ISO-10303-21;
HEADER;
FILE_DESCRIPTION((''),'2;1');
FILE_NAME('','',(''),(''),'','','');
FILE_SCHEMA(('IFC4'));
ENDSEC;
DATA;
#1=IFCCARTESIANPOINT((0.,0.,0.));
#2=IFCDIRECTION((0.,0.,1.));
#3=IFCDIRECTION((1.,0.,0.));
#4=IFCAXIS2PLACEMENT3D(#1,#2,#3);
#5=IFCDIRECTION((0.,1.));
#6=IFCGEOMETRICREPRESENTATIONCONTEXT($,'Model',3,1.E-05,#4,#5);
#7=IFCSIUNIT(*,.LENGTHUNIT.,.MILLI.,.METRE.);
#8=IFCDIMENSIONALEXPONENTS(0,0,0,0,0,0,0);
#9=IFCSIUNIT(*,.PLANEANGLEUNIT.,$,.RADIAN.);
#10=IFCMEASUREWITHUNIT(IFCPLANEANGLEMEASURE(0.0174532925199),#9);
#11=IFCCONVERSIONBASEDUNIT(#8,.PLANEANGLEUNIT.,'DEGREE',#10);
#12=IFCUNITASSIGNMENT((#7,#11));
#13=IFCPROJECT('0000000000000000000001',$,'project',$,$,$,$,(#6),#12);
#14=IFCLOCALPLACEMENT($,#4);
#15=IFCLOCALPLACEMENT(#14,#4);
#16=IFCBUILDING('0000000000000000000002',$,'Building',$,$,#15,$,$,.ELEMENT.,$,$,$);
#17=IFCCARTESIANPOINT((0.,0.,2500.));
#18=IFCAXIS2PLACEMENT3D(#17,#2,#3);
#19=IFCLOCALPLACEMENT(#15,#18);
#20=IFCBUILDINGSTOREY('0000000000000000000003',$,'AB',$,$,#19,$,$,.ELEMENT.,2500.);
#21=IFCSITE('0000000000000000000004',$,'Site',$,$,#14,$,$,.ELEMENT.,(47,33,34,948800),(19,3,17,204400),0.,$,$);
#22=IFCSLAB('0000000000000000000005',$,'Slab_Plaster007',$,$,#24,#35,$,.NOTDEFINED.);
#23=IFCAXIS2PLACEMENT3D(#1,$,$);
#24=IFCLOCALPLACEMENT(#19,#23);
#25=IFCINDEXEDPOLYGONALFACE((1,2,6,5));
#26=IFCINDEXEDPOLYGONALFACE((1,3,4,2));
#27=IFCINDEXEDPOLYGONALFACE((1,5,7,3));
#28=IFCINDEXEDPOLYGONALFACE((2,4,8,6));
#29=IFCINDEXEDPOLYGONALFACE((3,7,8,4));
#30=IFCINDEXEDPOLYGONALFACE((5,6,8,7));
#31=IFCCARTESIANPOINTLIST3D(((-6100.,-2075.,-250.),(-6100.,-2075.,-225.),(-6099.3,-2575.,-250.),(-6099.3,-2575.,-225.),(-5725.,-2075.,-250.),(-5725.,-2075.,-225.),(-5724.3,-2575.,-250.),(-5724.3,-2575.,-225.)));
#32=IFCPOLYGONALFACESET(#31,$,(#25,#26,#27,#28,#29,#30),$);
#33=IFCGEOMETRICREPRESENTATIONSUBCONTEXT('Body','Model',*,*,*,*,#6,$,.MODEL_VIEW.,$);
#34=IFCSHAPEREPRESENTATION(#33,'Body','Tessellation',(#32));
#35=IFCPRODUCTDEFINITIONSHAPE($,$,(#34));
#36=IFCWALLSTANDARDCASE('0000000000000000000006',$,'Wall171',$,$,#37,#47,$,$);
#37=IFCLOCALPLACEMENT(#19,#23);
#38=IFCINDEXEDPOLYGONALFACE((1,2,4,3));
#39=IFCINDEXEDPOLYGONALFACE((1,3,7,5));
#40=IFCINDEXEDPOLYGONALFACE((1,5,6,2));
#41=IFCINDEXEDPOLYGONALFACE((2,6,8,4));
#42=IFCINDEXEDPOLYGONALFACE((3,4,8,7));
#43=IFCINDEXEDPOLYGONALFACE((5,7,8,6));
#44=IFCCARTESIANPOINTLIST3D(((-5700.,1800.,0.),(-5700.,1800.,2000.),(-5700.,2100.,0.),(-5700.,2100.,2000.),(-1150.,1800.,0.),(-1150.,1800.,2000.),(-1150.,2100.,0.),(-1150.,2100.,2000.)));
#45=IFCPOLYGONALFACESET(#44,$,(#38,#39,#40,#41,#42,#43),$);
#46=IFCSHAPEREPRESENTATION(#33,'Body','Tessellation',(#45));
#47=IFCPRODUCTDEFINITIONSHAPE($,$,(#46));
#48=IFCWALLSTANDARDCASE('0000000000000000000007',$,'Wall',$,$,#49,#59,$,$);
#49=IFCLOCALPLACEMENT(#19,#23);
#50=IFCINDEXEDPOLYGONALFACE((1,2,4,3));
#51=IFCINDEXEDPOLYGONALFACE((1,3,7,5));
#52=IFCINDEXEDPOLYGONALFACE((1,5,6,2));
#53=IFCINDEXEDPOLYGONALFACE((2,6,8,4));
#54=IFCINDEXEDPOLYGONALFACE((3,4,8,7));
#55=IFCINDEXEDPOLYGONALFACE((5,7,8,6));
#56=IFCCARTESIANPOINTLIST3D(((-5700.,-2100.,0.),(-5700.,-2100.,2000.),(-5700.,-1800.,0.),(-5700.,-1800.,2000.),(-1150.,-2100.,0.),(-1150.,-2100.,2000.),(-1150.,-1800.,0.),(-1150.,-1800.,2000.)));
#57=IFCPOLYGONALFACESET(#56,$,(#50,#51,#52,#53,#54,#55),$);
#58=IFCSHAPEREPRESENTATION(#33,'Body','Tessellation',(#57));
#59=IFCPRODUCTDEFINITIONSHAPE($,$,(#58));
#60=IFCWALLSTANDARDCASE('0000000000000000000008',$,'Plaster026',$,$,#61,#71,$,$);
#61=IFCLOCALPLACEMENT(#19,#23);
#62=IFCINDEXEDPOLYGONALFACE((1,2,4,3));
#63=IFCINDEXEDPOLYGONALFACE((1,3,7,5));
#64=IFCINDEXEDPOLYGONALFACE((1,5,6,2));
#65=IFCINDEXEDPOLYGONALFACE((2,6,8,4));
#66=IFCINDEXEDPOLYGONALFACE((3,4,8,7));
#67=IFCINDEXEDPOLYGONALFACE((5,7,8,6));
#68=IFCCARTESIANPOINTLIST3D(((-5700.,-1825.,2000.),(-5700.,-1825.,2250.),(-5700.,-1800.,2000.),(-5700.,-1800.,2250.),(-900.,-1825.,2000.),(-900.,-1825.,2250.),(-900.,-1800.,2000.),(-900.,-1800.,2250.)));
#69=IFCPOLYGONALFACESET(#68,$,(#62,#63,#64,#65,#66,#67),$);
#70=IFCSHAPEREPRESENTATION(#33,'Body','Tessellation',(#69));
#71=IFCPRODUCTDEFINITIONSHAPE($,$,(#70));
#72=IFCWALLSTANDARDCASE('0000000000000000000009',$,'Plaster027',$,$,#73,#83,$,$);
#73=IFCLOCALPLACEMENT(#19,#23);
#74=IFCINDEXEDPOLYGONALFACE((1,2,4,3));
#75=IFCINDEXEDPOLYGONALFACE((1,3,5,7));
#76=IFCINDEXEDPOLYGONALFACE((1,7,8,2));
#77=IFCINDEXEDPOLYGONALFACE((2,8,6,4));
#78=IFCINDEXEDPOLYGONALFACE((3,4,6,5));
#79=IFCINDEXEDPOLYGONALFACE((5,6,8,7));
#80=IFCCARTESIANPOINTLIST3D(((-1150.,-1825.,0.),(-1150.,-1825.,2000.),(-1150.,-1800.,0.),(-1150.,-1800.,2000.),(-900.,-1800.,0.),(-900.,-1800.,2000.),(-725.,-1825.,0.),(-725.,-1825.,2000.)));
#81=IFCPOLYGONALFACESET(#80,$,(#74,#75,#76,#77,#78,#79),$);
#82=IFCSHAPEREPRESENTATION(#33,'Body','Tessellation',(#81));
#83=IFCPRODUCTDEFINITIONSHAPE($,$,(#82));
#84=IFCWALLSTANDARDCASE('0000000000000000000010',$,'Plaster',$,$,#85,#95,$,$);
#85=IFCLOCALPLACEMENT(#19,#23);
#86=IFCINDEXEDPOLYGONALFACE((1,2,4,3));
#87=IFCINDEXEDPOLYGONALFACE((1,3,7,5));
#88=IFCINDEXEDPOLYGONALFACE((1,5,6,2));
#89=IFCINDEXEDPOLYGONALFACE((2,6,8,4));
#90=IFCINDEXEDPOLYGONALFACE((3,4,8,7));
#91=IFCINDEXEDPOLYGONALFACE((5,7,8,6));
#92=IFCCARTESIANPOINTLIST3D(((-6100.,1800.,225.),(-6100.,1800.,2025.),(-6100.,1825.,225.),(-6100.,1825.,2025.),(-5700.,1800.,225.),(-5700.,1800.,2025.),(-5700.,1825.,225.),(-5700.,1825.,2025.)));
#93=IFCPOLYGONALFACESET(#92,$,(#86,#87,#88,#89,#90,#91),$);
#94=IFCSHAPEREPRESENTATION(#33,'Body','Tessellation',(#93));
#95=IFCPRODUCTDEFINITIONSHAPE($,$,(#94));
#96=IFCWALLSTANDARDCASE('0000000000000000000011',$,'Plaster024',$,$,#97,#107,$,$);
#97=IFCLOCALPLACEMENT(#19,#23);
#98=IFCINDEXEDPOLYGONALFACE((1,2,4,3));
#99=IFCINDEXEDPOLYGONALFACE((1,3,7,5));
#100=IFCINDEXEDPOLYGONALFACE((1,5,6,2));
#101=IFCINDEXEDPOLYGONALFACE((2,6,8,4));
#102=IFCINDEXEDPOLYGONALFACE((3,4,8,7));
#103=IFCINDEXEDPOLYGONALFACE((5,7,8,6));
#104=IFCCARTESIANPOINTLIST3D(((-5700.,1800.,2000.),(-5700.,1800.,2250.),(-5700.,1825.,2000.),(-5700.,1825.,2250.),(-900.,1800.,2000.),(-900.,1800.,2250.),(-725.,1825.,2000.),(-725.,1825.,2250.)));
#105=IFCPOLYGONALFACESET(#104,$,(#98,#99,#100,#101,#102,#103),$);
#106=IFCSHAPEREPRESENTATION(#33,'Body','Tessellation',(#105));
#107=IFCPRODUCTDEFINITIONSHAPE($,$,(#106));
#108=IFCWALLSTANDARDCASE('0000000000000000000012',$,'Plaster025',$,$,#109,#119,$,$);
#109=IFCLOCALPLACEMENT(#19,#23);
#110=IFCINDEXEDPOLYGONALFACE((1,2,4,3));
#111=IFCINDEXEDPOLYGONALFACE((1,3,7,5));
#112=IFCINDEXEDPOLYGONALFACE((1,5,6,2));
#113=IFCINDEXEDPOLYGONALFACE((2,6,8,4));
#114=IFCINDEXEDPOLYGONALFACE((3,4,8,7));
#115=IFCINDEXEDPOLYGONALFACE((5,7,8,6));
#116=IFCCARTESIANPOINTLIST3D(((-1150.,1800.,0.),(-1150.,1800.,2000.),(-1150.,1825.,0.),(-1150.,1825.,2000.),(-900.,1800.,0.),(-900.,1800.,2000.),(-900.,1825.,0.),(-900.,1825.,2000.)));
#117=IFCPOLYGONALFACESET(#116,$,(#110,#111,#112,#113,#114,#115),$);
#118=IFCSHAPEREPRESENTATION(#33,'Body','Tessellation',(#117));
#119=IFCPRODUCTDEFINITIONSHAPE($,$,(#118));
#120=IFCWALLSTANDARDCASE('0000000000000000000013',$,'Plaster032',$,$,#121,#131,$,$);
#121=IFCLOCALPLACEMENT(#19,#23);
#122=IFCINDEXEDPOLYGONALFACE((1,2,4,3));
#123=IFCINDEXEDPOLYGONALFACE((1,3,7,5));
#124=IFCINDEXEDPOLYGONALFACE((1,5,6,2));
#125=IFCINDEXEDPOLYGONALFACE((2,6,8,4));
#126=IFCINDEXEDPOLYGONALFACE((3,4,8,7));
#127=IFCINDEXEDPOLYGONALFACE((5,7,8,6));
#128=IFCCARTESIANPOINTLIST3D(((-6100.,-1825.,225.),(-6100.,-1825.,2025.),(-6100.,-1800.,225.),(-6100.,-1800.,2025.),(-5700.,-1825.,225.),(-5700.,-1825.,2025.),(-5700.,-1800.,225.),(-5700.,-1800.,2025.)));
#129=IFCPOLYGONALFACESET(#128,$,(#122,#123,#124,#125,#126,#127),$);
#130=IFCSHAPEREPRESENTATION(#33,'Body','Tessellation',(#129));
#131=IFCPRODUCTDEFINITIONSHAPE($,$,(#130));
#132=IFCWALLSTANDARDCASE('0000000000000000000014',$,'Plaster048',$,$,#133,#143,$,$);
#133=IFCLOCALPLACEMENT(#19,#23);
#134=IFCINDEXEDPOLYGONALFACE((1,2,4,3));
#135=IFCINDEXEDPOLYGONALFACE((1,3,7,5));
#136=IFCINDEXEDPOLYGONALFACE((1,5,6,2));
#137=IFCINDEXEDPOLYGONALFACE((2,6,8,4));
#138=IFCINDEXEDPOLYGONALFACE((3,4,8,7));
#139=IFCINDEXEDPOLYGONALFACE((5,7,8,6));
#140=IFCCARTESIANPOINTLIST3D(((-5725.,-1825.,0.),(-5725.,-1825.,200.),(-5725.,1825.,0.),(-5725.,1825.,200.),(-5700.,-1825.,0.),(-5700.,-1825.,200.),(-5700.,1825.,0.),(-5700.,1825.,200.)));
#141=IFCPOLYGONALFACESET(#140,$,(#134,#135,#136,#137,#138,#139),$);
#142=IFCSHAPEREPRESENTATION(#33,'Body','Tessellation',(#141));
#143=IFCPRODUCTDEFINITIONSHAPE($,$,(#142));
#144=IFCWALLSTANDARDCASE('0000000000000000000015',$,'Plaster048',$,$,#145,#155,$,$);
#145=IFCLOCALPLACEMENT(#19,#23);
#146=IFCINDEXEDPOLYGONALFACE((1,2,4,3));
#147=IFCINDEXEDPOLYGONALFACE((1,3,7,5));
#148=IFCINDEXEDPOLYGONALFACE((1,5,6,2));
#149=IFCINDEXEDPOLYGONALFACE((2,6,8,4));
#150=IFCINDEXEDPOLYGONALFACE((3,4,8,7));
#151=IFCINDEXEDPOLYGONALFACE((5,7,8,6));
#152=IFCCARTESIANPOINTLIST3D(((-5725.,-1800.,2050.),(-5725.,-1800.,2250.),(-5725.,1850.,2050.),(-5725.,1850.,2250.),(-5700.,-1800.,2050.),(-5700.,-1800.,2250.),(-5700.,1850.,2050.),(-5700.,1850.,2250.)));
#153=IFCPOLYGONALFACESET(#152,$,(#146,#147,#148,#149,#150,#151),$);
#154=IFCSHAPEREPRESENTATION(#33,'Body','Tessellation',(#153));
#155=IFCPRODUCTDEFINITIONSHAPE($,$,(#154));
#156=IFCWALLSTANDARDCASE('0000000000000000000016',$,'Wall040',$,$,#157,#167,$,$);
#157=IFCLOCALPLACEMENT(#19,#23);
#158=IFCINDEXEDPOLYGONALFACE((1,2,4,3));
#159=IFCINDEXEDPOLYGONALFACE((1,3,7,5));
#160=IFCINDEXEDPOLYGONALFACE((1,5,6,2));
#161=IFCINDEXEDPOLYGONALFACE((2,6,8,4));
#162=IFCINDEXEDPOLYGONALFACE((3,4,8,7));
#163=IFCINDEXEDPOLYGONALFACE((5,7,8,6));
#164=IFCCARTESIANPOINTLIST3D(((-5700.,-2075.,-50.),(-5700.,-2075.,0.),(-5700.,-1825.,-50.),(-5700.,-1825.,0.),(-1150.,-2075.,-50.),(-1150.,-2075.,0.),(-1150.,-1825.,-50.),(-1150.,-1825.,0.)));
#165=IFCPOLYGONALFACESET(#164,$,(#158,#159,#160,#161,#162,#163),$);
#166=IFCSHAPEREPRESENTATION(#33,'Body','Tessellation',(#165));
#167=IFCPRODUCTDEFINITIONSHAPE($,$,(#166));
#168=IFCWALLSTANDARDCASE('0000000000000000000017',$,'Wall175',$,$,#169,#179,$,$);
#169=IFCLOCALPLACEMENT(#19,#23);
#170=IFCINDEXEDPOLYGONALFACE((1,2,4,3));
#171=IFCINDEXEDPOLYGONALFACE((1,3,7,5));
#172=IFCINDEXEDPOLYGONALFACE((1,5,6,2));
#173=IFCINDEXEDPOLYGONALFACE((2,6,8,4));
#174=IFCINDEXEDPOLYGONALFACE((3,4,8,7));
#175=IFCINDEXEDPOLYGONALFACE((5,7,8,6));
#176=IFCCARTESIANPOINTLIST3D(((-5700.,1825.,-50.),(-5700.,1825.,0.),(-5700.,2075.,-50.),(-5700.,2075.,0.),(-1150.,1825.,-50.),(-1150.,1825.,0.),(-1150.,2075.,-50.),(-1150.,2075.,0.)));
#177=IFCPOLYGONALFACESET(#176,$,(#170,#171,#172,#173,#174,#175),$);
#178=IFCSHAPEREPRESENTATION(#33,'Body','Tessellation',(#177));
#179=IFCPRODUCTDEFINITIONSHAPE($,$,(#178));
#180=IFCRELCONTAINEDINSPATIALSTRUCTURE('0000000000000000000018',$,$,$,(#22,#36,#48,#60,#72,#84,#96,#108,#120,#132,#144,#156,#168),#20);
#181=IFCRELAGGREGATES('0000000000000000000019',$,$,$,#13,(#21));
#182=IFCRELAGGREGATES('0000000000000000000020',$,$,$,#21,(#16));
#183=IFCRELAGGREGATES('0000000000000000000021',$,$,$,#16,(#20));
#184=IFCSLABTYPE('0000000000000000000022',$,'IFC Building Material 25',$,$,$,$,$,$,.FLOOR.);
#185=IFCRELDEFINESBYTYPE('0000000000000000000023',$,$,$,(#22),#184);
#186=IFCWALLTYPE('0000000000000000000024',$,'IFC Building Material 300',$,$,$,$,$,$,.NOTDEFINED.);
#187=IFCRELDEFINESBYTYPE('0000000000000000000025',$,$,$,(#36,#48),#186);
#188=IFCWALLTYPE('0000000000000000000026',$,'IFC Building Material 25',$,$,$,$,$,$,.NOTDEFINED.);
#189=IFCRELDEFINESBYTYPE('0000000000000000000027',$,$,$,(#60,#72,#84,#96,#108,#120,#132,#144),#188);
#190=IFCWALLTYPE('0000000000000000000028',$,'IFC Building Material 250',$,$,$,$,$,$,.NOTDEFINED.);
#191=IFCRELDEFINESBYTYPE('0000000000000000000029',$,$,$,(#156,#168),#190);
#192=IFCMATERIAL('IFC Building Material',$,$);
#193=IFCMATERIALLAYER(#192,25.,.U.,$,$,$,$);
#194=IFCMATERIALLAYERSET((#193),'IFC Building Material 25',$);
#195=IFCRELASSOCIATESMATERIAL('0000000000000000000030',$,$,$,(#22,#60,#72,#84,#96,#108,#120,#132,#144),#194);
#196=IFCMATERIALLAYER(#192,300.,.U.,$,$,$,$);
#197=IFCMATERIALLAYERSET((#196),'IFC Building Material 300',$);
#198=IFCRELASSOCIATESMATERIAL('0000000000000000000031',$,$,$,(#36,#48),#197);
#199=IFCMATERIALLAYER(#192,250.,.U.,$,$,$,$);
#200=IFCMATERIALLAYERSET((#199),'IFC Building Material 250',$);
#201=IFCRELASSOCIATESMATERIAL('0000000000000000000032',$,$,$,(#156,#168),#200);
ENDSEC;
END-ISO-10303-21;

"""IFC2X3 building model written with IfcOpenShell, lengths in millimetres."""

from ifc_helpers import new_model, entity, si_unit, converted_unit, direction, frame, origin_with_axes, place, context, subcontext, project, spatial, polyline, outline, extrude, material, layer, layer_set, layer_usage, type_object, element, save


model = new_model("IFC2X3")

# Units and contexts
model_context = context("Model", 3, precision=1e-05, world=origin_with_axes(), true_north=direction((0.0, 1.0)))
body_context = subcontext(model_context, "Body", "Model", "MODEL_VIEW")
ifc_project = project(units=[si_unit("LENGTHUNIT", "METRE", prefix="MILLI"), converted_unit("PLANEANGLEUNIT", "DEGREE", entity("IfcPlaneAngleMeasure", 0.0174532925199), si_unit("PLANEANGLEUNIT", "RADIAN"), dimensions=[0, 0, 0, 0, 0, 0, 0])], contexts=[model_context])

# Site, building, storey
site_placement = place(None, origin_with_axes())
site = spatial("IfcSite", under=ifc_project, at=site_placement, Name="Site", CompositionType="ELEMENT", RefLatitude=(47, 33, 34, 948800), RefLongitude=(19, 3, 17, 204400), RefElevation=0.0)
building_placement = place(site_placement, origin_with_axes())
building = spatial("IfcBuilding", under=site, at=building_placement, Name="Building", CompositionType="ELEMENT")
storey_placement = place(building_placement, frame((0.0, 0.0, 2500.0), z_axis=(0.0, 0.0, 1.0), x_axis=(1.0, 0.0, 0.0)))
storey = spatial("IfcBuildingStorey", under=building, at=storey_placement, Name="AB", CompositionType="ELEMENT", Elevation=2500.0)

# Shared definitions
ifc_material = material(Name="IFC Building Material")

# Slab
ifc_layer_1 = layer(ifc_material, 250.0, ventilated="UNKNOWN")
ifc_layer_set_1 = layer_set([ifc_layer_1], Name="IFC Building Material 250")
ifc_layer_2 = layer(ifc_material, 25.0, ventilated="UNKNOWN")
ifc_layer_set_2 = layer_set([ifc_layer_2], Name="IFC Building Material 25")
slab_type_1 = type_object("IfcSlabType", Name="IFC Building Material 25", PredefinedType="FLOOR")
ifc_layer_usage_1 = layer_usage(ifc_layer_set_2, "AXIS3", "NEGATIVE", 25.0)
slab_1_placement = place(storey_placement, frame((-5725.0, -2075.0, -225.0), z_axis=(0.0, 0.0, 1.0), x_axis=(1.0, 0.0, 0.0)))
element("IfcSlab", 1, at=slab_1_placement, inside=storey, type_object=slab_type_1, material=ifc_layer_usage_1, Name="Slab_Plaster007", PredefinedType="NOTDEFINED", context=body_context, shape_type="SweptSolid", body=[
    extrude(outline(polyline([(0.0, 0.0), (-375.0, 0.0), (-374.3, -500.0), (0.7, -500.0), (0.0, 0.0)])), frame((0.0, 0.0, -25.0), z_axis=(0.0, 0.0, 1.0), x_axis=(1.0, 0.0, 0.0)), (0.0, 0.0, 1.0), 25.0),
])

# Walls
ifc_layer_3 = layer(ifc_material, 300.0, ventilated="UNKNOWN")
ifc_layer_set_3 = layer_set([ifc_layer_3], Name="IFC Building Material 300")
ifc_layer_usage_2 = layer_usage(ifc_layer_set_3, "AXIS2", "NEGATIVE", 0.0)
wall_type_1 = type_object("IfcWallType", Name="IFC Building Material 300", PredefinedType="NOTDEFINED")
wall_1_placement = place(storey_placement, frame((-1150.0, 1800.0, 0.0), z_axis=(0.0, 0.0, 1.0), x_axis=(-1.0, 0.0, 0.0)))
element("IfcWallStandardCase", 2, at=wall_1_placement, inside=storey, type_object=wall_type_1, material=ifc_layer_usage_2, Name="Wall171", context=body_context, shape_type="SweptSolid", body=[
    extrude(outline(polyline([(0.0, -300.0), (4550.0, -300.0), (4550.0, 0.0), (0.0, 0.0), (0.0, -300.0)])), origin_with_axes(), (0.0, 0.0, 1.0), 2000.0),
])
ifc_layer_usage_3 = layer_usage(ifc_layer_set_3, "AXIS2", "NEGATIVE", 300.0)
wall_2_placement = place(storey_placement, frame((-1150.0, -1800.0, 0.0), z_axis=(0.0, 0.0, 1.0), x_axis=(-1.0, 0.0, 0.0)))
element("IfcWallStandardCase", 3, at=wall_2_placement, inside=storey, type_object=wall_type_1, material=ifc_layer_usage_3, Name="Wall", context=body_context, shape_type="SweptSolid", body=[
    extrude(outline(polyline([(0.0, 0.0), (4550.0, 0.0), (4550.0, 300.0), (0.0, 300.0), (0.0, 0.0)])), origin_with_axes(), (0.0, 0.0, 1.0), 2000.0),
])
ifc_layer_usage_4 = layer_usage(ifc_layer_set_2, "AXIS2", "POSITIVE", -25.0)
wall_type_2 = type_object("IfcWallType", Name="IFC Building Material 25", PredefinedType="NOTDEFINED")
wall_3_placement = place(storey_placement, frame((-900.0, -1825.0, 2000.0), z_axis=(0.0, 0.0, 1.0), x_axis=(-1.0, 0.0, 0.0)))
element("IfcWallStandardCase", 4, at=wall_3_placement, inside=storey, type_object=wall_type_2, material=ifc_layer_usage_4, Name="Plaster026", context=body_context, shape_type="SweptSolid", body=[
    extrude(outline(polyline([(0.0, -25.0), (4800.0, -25.0), (4800.0, 0.0), (0.0, 0.0), (0.0, -25.0)])), origin_with_axes(), (0.0, 0.0, 1.0), 250.0),
])
ifc_layer_usage_5 = layer_usage(ifc_layer_set_2, "AXIS2", "POSITIVE", -25.0)
wall_4_placement = place(storey_placement, frame((-1150.0, -1800.0, 0.0), z_axis=(0.0, 0.0, 1.0), x_axis=(1.0, 0.0, 0.0)))
element("IfcWallStandardCase", 5, at=wall_4_placement, inside=storey, type_object=wall_type_2, material=ifc_layer_usage_5, Name="Plaster027", context=body_context, shape_type="SweptSolid", body=[
    extrude(outline(polyline([(0.0, -25.0), (425.0, -25.0), (250.0, 0.0), (0.0, 0.0), (0.0, -25.0)])), origin_with_axes(), (0.0, 0.0, 1.0), 2000.0),
])
ifc_layer_usage_6 = layer_usage(ifc_layer_set_2, "AXIS2", "POSITIVE", 0.0)
wall_5_placement = place(storey_placement, frame((-6100.0, 1800.0, 225.0), z_axis=(0.0, 0.0, 1.0), x_axis=(1.0, 0.0, 0.0)))
element("IfcWallStandardCase", 6, at=wall_5_placement, inside=storey, type_object=wall_type_2, material=ifc_layer_usage_6, Name="Plaster", context=body_context, shape_type="SweptSolid", body=[
    extrude(outline(polyline([(0.0, 0.0), (400.0, 0.0), (400.0, 25.0), (0.0, 25.0), (0.0, 0.0)])), origin_with_axes(), (0.0, 0.0, 1.0), 1800.0),
])
ifc_layer_usage_7 = layer_usage(ifc_layer_set_2, "AXIS2", "POSITIVE", 0.0)
wall_6_placement = place(storey_placement, frame((-900.0, 1825.0, 2000.0), z_axis=(0.0, 0.0, 1.0), x_axis=(-1.0, 0.0, 0.0)))
element("IfcWallStandardCase", 7, at=wall_6_placement, inside=storey, type_object=wall_type_2, material=ifc_layer_usage_7, Name="Plaster024", context=body_context, shape_type="SweptSolid", body=[
    extrude(outline(polyline([(-175.0, 0.0), (4800.0, 0.0), (4800.0, 25.0), (0.0, 25.0), (-175.0, 0.0)])), origin_with_axes(), (0.0, 0.0, 1.0), 250.0),
])
ifc_layer_usage_8 = layer_usage(ifc_layer_set_2, "AXIS2", "POSITIVE", 0.0)
wall_7_placement = place(storey_placement, frame((-1150.0, 1800.0, 0.0), z_axis=(0.0, 0.0, 1.0), x_axis=(1.0, 0.0, 0.0)))
element("IfcWallStandardCase", 8, at=wall_7_placement, inside=storey, type_object=wall_type_2, material=ifc_layer_usage_8, Name="Plaster025", context=body_context, shape_type="SweptSolid", body=[
    extrude(outline(polyline([(0.0, 0.0), (250.0, 0.0), (250.0, 25.0), (0.0, 25.0), (0.0, 0.0)])), origin_with_axes(), (0.0, 0.0, 1.0), 2000.0),
])
ifc_layer_usage_9 = layer_usage(ifc_layer_set_2, "AXIS2", "POSITIVE", -25.0)
wall_8_placement = place(storey_placement, frame((-6100.0, -1800.0, 225.0), z_axis=(0.0, 0.0, 1.0), x_axis=(1.0, 0.0, 0.0)))
element("IfcWallStandardCase", 9, at=wall_8_placement, inside=storey, type_object=wall_type_2, material=ifc_layer_usage_9, Name="Plaster032", context=body_context, shape_type="SweptSolid", body=[
    extrude(outline(polyline([(0.0, -25.0), (400.0, -25.0), (400.0, 0.0), (0.0, 0.0), (0.0, -25.0)])), origin_with_axes(), (0.0, 0.0, 1.0), 1800.0),
])
ifc_layer_usage_10 = layer_usage(ifc_layer_set_2, "AXIS2", "NEGATIVE", 0.0)
wall_9_placement = place(storey_placement, frame((-5725.0, -1825.0, 0.0), z_axis=(0.0, 0.0, 1.0), x_axis=(0.0, 1.0, 0.0)))
element("IfcWallStandardCase", 10, at=wall_9_placement, inside=storey, type_object=wall_type_2, material=ifc_layer_usage_10, Name="Plaster048", context=body_context, shape_type="SweptSolid", body=[
    extrude(outline(polyline([(0.0, -25.0), (3650.0, -25.0), (3650.0, 0.0), (0.0, 0.0), (0.0, -25.0)])), origin_with_axes(), (0.0, 0.0, 1.0), 200.0),
])
ifc_layer_usage_11 = layer_usage(ifc_layer_set_2, "AXIS2", "NEGATIVE", 0.0)
wall_10_placement = place(storey_placement, frame((-5725.0, -1800.0, 2050.0), z_axis=(0.0, 0.0, 1.0), x_axis=(0.0, 1.0, 0.0)))
element("IfcWallStandardCase", 11, at=wall_10_placement, inside=storey, type_object=wall_type_2, material=ifc_layer_usage_11, Name="Plaster048", context=body_context, shape_type="SweptSolid", body=[
    extrude(outline(polyline([(0.0, -25.0), (3650.0, -25.0), (3650.0, 0.0), (0.0, 0.0), (0.0, -25.0)])), origin_with_axes(), (0.0, 0.0, 1.0), 200.0),
])
ifc_layer_usage_12 = layer_usage(ifc_layer_set_1, "AXIS2", "POSITIVE", -250.0)
wall_type_3 = type_object("IfcWallType", Name="IFC Building Material 250", PredefinedType="NOTDEFINED")
wall_11_placement = place(storey_placement, frame((-1150.0, -2075.0, -50.0), z_axis=(0.0, 0.0, 1.0), x_axis=(-1.0, 0.0, 0.0)))
element("IfcWallStandardCase", 12, at=wall_11_placement, inside=storey, type_object=wall_type_3, material=ifc_layer_usage_12, Name="Wall040", context=body_context, shape_type="SweptSolid", body=[
    extrude(outline(polyline([(0.0, -250.0), (4550.0, -250.0), (4550.0, 0.0), (0.0, 0.0), (0.0, -250.0)])), origin_with_axes(), (0.0, 0.0, 1.0), 50.0),
])
ifc_layer_usage_13 = layer_usage(ifc_layer_set_1, "AXIS2", "POSITIVE", 0.0)
wall_12_placement = place(storey_placement, frame((-1150.0, 2075.0, -50.0), z_axis=(0.0, 0.0, 1.0), x_axis=(-1.0, 0.0, 0.0)))
element("IfcWallStandardCase", 13, at=wall_12_placement, inside=storey, type_object=wall_type_3, material=ifc_layer_usage_13, Name="Wall175", context=body_context, shape_type="SweptSolid", body=[
    extrude(outline(polyline([(0.0, 0.0), (4550.0, 0.0), (4550.0, 250.0), (0.0, 250.0), (0.0, 0.0)])), origin_with_axes(), (0.0, 0.0, 1.0), 50.0),
])

save(model, "model.ifc")
